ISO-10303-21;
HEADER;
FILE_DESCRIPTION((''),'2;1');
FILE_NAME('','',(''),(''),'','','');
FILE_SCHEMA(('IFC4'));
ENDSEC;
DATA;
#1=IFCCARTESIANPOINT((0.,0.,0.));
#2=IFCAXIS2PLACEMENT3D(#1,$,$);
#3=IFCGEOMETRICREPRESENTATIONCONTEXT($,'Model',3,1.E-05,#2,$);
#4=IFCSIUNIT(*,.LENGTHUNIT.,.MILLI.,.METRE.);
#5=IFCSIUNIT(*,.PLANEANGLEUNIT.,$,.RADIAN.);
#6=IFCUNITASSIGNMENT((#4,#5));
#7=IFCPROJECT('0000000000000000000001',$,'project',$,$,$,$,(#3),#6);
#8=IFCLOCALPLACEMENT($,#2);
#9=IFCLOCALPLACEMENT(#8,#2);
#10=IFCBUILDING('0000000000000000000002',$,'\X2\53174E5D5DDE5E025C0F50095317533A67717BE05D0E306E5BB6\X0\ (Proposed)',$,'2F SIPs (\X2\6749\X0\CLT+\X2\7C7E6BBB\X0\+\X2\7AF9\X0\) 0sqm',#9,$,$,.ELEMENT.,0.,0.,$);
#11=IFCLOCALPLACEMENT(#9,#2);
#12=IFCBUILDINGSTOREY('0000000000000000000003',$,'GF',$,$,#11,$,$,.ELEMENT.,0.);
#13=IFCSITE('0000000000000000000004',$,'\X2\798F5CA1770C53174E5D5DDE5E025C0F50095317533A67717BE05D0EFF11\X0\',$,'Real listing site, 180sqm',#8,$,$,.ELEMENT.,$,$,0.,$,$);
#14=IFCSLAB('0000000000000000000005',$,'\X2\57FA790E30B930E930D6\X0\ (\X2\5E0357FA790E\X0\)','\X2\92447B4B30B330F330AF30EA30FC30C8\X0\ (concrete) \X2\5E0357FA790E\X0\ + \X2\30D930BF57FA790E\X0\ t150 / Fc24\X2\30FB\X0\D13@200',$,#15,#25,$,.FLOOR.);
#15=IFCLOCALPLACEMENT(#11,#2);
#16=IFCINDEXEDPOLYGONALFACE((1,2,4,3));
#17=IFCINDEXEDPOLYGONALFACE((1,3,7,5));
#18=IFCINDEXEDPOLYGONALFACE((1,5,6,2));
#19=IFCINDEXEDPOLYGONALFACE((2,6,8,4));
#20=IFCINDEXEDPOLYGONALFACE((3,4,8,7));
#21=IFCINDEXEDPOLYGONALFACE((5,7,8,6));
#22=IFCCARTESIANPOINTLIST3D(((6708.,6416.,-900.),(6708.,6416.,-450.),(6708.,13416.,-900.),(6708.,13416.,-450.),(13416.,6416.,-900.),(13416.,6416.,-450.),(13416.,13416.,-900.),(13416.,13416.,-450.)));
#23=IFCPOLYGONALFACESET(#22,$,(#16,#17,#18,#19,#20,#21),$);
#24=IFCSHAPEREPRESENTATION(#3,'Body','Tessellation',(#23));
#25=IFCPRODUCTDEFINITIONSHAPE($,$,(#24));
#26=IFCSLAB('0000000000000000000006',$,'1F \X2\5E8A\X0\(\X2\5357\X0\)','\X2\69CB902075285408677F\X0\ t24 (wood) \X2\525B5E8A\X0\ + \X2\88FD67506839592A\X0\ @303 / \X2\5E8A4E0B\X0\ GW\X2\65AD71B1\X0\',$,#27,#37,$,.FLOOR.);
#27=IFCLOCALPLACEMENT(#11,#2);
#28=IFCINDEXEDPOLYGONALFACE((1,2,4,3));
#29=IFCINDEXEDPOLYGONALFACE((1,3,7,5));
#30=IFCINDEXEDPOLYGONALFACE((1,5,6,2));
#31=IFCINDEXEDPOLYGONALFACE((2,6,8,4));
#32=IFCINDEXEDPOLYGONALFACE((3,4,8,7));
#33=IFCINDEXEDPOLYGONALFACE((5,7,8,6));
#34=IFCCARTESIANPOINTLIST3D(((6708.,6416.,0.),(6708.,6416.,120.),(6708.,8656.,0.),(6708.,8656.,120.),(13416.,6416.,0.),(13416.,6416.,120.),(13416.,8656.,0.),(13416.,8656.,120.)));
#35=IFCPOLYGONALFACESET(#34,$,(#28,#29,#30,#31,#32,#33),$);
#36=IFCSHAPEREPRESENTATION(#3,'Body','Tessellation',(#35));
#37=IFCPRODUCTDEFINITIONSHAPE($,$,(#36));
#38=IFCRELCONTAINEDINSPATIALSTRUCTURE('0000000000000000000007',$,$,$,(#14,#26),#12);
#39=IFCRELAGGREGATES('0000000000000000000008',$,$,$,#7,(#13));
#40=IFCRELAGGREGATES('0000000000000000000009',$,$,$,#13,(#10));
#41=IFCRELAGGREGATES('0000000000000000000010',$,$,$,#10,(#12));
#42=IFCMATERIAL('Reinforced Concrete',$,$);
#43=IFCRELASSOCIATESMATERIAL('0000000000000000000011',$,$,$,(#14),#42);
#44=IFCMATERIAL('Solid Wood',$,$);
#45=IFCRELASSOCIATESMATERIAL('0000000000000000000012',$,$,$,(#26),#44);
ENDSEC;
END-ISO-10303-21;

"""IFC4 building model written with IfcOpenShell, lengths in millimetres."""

from ifc_helpers import new_model, si_unit, frame, frame_2d, origin, place, context, project, spatial, rectangle, extrude, material, element, save


model = new_model("IFC4")

# Units and contexts
model_context = context("Model", 3, precision=1e-05, world=origin())
ifc_project = project(units=[si_unit("LENGTHUNIT", "METRE", prefix="MILLI"), si_unit("PLANEANGLEUNIT", "RADIAN")], contexts=[model_context])

# Site, building, storey
site_placement = place(None, origin())
site = spatial("IfcSite", under=ifc_project, at=site_placement, Name="福岡県北九州市小倉北区東篠崎１", ObjectType="Real listing site, 180sqm", CompositionType="ELEMENT", RefElevation=0.0)
building_placement = place(site_placement, origin())
building = spatial("IfcBuilding", under=site, at=building_placement, Name="北九州市小倉北区東篠崎の家 (Proposed)", ObjectType="2F SIPs (杉CLT+籾殻+竹) 0sqm", CompositionType="ELEMENT", ElevationOfRefHeight=0.0, ElevationOfTerrain=0.0)
storey_placement = place(building_placement, origin())
storey = spatial("IfcBuildingStorey", under=building, at=storey_placement, Name="GF", CompositionType="ELEMENT", Elevation=0.0)

# Slabs
ifc_material_1 = material(Name="Reinforced Concrete")
slab_1_placement = place(storey_placement, frame((3354.0, 3208.0, -450.0)))
element("IfcSlab", 1, at=slab_1_placement, inside=storey, material=ifc_material_1, Name="基礎スラブ (布基礎)", Description="鉄筋コンクリート (concrete) 布基礎 + ベタ基礎 t150 / Fc24・D13@200", PredefinedType="FLOOR", context=model_context, shape_type="SweptSolid", body=[
    extrude(rectangle(XDim=6708.0, YDim=7000.0, at=frame_2d((3354.0, 3500.0))), frame((3354.0, 3208.0, -450.0)), (0.0, 0.0, 1.0), 450.0),
])
ifc_material_2 = material(Name="Solid Wood")
slab_2_placement = place(storey_placement, frame((3354.0, 3208.0, 0.0)))
element("IfcSlab", 2, at=slab_2_placement, inside=storey, material=ifc_material_2, Name="1F 床(南)", Description="構造用合板 t24 (wood) 剛床 + 製材根太 @303 / 床下 GW断熱", PredefinedType="FLOOR", context=model_context, shape_type="SweptSolid", body=[
    extrude(rectangle(XDim=6708.0, YDim=2240.0, at=frame_2d((3354.0, 1120.0))), frame((3354.0, 3208.0, 0.0)), (0.0, 0.0, 1.0), 120.0),
])

save(model, "model.ifc")
